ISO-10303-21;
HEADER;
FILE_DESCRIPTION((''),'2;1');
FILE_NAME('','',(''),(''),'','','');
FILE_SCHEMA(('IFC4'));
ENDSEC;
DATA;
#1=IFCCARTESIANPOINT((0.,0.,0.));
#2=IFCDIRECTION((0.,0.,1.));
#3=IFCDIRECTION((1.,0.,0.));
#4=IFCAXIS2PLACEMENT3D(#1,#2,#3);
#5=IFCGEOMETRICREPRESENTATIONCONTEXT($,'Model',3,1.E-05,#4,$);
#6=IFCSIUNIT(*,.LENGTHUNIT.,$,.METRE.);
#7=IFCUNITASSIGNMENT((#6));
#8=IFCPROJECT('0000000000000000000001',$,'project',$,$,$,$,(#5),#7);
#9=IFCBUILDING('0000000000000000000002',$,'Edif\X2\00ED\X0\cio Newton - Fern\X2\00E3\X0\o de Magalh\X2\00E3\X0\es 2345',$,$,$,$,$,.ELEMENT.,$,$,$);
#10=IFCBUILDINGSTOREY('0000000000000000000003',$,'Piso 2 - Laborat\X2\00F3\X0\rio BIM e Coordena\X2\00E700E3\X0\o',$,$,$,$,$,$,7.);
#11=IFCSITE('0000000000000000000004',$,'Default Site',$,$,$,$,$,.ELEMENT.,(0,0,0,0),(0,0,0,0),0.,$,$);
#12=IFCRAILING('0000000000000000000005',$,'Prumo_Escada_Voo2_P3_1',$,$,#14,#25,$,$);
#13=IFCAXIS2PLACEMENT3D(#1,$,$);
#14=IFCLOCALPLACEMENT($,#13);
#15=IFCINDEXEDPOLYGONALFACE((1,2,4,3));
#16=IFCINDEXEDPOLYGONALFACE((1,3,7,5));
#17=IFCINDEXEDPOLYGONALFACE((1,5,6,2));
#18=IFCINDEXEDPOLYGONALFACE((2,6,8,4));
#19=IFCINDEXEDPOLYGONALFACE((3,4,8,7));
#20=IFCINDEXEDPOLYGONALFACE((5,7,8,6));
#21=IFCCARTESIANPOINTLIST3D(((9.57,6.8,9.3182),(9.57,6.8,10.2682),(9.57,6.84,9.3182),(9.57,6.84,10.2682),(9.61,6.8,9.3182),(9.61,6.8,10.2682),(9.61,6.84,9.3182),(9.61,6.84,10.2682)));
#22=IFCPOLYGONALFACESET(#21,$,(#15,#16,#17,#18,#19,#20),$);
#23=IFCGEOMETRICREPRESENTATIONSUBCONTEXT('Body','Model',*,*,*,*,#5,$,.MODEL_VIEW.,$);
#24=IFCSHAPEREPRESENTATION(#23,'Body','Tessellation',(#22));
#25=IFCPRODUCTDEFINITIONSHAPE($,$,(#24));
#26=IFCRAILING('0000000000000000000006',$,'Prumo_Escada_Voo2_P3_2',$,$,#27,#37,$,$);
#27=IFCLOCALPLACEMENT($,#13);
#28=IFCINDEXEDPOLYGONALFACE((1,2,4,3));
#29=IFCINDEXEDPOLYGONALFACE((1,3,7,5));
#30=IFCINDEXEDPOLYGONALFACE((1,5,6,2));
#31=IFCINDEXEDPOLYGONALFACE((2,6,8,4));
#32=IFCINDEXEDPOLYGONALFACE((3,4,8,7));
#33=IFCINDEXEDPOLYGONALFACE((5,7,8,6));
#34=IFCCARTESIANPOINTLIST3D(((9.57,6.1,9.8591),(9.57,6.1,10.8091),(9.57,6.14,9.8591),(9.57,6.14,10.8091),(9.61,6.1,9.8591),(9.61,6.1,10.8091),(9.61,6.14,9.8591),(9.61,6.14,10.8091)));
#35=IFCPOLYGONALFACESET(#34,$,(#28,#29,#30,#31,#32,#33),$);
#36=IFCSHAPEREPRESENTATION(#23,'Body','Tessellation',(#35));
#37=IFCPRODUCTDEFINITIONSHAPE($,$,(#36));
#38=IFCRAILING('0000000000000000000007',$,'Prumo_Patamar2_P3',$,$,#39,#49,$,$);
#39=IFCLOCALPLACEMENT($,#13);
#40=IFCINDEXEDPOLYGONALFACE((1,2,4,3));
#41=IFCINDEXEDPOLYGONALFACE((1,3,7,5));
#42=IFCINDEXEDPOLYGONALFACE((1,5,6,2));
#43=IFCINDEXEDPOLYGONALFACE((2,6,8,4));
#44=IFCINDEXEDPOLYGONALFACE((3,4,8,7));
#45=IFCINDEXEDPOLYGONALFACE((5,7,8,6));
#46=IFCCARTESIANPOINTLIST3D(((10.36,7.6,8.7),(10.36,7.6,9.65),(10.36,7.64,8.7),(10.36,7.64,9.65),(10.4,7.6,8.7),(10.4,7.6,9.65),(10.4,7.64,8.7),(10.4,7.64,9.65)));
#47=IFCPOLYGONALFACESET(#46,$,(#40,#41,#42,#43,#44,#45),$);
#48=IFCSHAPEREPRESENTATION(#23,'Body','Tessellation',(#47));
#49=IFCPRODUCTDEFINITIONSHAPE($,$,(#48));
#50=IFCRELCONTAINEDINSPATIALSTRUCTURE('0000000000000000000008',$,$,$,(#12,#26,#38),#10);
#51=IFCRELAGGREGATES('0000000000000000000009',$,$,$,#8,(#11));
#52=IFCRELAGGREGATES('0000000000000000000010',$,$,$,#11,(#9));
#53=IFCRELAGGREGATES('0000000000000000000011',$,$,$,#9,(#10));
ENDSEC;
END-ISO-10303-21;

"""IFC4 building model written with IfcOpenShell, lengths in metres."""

from ifc_helpers import new_model, si_unit, frame, frame_2d, origin_with_axes, place, context, subcontext, project, spatial, rectangle, extrude, element, save


model = new_model("IFC4")

# Units and contexts
model_context = context("Model", 3, precision=1e-05, world=origin_with_axes())
body_context = subcontext(model_context, "Body", "Model", "MODEL_VIEW")
ifc_project = project(units=[si_unit("LENGTHUNIT", "METRE")], contexts=[model_context])

# Site, building, storey
site = spatial("IfcSite", under=ifc_project, Name="Default Site", CompositionType="ELEMENT", RefLatitude=(0, 0, 0, 0), RefLongitude=(0, 0, 0, 0), RefElevation=0.0)
building = spatial("IfcBuilding", under=site, Name="Edifício Newton - Fernão de Magalhães 2345", CompositionType="ELEMENT")
storey = spatial("IfcBuildingStorey", under=building, Name="Piso 2 - Laboratório BIM e Coordenação", Elevation=7.0)

# Railings
for number, where, z_axis, x_axis, name in (
    (1, (9.57, 6.8, 9.3182), (0.0, 0.0, 1.0), (1.0, 0.0, 0.0), "Prumo_Escada_Voo2_P3_1"),
    (2, (9.57, 6.1, 9.8591), (0.0, 0.0, 1.0), (1.0, 0.0, 0.0), "Prumo_Escada_Voo2_P3_2"),
    (3, (10.36, 7.6, 8.7), (0.0, 0.0, 1.0), (1.0, 0.0, 0.0), "Prumo_Patamar2_P3"),
):
    element("IfcRailing", number, at=place(None, frame(where, z_axis=z_axis, x_axis=x_axis)), inside=storey, Name=name, context=body_context, shape_type="SweptSolid", body=[
        extrude(rectangle(XDim=0.04, YDim=0.04, at=frame_2d((0.02, 0.02))), origin_with_axes(), (0.0, 0.0, 1.0), 0.95),
    ])

save(model, "model.ifc")
